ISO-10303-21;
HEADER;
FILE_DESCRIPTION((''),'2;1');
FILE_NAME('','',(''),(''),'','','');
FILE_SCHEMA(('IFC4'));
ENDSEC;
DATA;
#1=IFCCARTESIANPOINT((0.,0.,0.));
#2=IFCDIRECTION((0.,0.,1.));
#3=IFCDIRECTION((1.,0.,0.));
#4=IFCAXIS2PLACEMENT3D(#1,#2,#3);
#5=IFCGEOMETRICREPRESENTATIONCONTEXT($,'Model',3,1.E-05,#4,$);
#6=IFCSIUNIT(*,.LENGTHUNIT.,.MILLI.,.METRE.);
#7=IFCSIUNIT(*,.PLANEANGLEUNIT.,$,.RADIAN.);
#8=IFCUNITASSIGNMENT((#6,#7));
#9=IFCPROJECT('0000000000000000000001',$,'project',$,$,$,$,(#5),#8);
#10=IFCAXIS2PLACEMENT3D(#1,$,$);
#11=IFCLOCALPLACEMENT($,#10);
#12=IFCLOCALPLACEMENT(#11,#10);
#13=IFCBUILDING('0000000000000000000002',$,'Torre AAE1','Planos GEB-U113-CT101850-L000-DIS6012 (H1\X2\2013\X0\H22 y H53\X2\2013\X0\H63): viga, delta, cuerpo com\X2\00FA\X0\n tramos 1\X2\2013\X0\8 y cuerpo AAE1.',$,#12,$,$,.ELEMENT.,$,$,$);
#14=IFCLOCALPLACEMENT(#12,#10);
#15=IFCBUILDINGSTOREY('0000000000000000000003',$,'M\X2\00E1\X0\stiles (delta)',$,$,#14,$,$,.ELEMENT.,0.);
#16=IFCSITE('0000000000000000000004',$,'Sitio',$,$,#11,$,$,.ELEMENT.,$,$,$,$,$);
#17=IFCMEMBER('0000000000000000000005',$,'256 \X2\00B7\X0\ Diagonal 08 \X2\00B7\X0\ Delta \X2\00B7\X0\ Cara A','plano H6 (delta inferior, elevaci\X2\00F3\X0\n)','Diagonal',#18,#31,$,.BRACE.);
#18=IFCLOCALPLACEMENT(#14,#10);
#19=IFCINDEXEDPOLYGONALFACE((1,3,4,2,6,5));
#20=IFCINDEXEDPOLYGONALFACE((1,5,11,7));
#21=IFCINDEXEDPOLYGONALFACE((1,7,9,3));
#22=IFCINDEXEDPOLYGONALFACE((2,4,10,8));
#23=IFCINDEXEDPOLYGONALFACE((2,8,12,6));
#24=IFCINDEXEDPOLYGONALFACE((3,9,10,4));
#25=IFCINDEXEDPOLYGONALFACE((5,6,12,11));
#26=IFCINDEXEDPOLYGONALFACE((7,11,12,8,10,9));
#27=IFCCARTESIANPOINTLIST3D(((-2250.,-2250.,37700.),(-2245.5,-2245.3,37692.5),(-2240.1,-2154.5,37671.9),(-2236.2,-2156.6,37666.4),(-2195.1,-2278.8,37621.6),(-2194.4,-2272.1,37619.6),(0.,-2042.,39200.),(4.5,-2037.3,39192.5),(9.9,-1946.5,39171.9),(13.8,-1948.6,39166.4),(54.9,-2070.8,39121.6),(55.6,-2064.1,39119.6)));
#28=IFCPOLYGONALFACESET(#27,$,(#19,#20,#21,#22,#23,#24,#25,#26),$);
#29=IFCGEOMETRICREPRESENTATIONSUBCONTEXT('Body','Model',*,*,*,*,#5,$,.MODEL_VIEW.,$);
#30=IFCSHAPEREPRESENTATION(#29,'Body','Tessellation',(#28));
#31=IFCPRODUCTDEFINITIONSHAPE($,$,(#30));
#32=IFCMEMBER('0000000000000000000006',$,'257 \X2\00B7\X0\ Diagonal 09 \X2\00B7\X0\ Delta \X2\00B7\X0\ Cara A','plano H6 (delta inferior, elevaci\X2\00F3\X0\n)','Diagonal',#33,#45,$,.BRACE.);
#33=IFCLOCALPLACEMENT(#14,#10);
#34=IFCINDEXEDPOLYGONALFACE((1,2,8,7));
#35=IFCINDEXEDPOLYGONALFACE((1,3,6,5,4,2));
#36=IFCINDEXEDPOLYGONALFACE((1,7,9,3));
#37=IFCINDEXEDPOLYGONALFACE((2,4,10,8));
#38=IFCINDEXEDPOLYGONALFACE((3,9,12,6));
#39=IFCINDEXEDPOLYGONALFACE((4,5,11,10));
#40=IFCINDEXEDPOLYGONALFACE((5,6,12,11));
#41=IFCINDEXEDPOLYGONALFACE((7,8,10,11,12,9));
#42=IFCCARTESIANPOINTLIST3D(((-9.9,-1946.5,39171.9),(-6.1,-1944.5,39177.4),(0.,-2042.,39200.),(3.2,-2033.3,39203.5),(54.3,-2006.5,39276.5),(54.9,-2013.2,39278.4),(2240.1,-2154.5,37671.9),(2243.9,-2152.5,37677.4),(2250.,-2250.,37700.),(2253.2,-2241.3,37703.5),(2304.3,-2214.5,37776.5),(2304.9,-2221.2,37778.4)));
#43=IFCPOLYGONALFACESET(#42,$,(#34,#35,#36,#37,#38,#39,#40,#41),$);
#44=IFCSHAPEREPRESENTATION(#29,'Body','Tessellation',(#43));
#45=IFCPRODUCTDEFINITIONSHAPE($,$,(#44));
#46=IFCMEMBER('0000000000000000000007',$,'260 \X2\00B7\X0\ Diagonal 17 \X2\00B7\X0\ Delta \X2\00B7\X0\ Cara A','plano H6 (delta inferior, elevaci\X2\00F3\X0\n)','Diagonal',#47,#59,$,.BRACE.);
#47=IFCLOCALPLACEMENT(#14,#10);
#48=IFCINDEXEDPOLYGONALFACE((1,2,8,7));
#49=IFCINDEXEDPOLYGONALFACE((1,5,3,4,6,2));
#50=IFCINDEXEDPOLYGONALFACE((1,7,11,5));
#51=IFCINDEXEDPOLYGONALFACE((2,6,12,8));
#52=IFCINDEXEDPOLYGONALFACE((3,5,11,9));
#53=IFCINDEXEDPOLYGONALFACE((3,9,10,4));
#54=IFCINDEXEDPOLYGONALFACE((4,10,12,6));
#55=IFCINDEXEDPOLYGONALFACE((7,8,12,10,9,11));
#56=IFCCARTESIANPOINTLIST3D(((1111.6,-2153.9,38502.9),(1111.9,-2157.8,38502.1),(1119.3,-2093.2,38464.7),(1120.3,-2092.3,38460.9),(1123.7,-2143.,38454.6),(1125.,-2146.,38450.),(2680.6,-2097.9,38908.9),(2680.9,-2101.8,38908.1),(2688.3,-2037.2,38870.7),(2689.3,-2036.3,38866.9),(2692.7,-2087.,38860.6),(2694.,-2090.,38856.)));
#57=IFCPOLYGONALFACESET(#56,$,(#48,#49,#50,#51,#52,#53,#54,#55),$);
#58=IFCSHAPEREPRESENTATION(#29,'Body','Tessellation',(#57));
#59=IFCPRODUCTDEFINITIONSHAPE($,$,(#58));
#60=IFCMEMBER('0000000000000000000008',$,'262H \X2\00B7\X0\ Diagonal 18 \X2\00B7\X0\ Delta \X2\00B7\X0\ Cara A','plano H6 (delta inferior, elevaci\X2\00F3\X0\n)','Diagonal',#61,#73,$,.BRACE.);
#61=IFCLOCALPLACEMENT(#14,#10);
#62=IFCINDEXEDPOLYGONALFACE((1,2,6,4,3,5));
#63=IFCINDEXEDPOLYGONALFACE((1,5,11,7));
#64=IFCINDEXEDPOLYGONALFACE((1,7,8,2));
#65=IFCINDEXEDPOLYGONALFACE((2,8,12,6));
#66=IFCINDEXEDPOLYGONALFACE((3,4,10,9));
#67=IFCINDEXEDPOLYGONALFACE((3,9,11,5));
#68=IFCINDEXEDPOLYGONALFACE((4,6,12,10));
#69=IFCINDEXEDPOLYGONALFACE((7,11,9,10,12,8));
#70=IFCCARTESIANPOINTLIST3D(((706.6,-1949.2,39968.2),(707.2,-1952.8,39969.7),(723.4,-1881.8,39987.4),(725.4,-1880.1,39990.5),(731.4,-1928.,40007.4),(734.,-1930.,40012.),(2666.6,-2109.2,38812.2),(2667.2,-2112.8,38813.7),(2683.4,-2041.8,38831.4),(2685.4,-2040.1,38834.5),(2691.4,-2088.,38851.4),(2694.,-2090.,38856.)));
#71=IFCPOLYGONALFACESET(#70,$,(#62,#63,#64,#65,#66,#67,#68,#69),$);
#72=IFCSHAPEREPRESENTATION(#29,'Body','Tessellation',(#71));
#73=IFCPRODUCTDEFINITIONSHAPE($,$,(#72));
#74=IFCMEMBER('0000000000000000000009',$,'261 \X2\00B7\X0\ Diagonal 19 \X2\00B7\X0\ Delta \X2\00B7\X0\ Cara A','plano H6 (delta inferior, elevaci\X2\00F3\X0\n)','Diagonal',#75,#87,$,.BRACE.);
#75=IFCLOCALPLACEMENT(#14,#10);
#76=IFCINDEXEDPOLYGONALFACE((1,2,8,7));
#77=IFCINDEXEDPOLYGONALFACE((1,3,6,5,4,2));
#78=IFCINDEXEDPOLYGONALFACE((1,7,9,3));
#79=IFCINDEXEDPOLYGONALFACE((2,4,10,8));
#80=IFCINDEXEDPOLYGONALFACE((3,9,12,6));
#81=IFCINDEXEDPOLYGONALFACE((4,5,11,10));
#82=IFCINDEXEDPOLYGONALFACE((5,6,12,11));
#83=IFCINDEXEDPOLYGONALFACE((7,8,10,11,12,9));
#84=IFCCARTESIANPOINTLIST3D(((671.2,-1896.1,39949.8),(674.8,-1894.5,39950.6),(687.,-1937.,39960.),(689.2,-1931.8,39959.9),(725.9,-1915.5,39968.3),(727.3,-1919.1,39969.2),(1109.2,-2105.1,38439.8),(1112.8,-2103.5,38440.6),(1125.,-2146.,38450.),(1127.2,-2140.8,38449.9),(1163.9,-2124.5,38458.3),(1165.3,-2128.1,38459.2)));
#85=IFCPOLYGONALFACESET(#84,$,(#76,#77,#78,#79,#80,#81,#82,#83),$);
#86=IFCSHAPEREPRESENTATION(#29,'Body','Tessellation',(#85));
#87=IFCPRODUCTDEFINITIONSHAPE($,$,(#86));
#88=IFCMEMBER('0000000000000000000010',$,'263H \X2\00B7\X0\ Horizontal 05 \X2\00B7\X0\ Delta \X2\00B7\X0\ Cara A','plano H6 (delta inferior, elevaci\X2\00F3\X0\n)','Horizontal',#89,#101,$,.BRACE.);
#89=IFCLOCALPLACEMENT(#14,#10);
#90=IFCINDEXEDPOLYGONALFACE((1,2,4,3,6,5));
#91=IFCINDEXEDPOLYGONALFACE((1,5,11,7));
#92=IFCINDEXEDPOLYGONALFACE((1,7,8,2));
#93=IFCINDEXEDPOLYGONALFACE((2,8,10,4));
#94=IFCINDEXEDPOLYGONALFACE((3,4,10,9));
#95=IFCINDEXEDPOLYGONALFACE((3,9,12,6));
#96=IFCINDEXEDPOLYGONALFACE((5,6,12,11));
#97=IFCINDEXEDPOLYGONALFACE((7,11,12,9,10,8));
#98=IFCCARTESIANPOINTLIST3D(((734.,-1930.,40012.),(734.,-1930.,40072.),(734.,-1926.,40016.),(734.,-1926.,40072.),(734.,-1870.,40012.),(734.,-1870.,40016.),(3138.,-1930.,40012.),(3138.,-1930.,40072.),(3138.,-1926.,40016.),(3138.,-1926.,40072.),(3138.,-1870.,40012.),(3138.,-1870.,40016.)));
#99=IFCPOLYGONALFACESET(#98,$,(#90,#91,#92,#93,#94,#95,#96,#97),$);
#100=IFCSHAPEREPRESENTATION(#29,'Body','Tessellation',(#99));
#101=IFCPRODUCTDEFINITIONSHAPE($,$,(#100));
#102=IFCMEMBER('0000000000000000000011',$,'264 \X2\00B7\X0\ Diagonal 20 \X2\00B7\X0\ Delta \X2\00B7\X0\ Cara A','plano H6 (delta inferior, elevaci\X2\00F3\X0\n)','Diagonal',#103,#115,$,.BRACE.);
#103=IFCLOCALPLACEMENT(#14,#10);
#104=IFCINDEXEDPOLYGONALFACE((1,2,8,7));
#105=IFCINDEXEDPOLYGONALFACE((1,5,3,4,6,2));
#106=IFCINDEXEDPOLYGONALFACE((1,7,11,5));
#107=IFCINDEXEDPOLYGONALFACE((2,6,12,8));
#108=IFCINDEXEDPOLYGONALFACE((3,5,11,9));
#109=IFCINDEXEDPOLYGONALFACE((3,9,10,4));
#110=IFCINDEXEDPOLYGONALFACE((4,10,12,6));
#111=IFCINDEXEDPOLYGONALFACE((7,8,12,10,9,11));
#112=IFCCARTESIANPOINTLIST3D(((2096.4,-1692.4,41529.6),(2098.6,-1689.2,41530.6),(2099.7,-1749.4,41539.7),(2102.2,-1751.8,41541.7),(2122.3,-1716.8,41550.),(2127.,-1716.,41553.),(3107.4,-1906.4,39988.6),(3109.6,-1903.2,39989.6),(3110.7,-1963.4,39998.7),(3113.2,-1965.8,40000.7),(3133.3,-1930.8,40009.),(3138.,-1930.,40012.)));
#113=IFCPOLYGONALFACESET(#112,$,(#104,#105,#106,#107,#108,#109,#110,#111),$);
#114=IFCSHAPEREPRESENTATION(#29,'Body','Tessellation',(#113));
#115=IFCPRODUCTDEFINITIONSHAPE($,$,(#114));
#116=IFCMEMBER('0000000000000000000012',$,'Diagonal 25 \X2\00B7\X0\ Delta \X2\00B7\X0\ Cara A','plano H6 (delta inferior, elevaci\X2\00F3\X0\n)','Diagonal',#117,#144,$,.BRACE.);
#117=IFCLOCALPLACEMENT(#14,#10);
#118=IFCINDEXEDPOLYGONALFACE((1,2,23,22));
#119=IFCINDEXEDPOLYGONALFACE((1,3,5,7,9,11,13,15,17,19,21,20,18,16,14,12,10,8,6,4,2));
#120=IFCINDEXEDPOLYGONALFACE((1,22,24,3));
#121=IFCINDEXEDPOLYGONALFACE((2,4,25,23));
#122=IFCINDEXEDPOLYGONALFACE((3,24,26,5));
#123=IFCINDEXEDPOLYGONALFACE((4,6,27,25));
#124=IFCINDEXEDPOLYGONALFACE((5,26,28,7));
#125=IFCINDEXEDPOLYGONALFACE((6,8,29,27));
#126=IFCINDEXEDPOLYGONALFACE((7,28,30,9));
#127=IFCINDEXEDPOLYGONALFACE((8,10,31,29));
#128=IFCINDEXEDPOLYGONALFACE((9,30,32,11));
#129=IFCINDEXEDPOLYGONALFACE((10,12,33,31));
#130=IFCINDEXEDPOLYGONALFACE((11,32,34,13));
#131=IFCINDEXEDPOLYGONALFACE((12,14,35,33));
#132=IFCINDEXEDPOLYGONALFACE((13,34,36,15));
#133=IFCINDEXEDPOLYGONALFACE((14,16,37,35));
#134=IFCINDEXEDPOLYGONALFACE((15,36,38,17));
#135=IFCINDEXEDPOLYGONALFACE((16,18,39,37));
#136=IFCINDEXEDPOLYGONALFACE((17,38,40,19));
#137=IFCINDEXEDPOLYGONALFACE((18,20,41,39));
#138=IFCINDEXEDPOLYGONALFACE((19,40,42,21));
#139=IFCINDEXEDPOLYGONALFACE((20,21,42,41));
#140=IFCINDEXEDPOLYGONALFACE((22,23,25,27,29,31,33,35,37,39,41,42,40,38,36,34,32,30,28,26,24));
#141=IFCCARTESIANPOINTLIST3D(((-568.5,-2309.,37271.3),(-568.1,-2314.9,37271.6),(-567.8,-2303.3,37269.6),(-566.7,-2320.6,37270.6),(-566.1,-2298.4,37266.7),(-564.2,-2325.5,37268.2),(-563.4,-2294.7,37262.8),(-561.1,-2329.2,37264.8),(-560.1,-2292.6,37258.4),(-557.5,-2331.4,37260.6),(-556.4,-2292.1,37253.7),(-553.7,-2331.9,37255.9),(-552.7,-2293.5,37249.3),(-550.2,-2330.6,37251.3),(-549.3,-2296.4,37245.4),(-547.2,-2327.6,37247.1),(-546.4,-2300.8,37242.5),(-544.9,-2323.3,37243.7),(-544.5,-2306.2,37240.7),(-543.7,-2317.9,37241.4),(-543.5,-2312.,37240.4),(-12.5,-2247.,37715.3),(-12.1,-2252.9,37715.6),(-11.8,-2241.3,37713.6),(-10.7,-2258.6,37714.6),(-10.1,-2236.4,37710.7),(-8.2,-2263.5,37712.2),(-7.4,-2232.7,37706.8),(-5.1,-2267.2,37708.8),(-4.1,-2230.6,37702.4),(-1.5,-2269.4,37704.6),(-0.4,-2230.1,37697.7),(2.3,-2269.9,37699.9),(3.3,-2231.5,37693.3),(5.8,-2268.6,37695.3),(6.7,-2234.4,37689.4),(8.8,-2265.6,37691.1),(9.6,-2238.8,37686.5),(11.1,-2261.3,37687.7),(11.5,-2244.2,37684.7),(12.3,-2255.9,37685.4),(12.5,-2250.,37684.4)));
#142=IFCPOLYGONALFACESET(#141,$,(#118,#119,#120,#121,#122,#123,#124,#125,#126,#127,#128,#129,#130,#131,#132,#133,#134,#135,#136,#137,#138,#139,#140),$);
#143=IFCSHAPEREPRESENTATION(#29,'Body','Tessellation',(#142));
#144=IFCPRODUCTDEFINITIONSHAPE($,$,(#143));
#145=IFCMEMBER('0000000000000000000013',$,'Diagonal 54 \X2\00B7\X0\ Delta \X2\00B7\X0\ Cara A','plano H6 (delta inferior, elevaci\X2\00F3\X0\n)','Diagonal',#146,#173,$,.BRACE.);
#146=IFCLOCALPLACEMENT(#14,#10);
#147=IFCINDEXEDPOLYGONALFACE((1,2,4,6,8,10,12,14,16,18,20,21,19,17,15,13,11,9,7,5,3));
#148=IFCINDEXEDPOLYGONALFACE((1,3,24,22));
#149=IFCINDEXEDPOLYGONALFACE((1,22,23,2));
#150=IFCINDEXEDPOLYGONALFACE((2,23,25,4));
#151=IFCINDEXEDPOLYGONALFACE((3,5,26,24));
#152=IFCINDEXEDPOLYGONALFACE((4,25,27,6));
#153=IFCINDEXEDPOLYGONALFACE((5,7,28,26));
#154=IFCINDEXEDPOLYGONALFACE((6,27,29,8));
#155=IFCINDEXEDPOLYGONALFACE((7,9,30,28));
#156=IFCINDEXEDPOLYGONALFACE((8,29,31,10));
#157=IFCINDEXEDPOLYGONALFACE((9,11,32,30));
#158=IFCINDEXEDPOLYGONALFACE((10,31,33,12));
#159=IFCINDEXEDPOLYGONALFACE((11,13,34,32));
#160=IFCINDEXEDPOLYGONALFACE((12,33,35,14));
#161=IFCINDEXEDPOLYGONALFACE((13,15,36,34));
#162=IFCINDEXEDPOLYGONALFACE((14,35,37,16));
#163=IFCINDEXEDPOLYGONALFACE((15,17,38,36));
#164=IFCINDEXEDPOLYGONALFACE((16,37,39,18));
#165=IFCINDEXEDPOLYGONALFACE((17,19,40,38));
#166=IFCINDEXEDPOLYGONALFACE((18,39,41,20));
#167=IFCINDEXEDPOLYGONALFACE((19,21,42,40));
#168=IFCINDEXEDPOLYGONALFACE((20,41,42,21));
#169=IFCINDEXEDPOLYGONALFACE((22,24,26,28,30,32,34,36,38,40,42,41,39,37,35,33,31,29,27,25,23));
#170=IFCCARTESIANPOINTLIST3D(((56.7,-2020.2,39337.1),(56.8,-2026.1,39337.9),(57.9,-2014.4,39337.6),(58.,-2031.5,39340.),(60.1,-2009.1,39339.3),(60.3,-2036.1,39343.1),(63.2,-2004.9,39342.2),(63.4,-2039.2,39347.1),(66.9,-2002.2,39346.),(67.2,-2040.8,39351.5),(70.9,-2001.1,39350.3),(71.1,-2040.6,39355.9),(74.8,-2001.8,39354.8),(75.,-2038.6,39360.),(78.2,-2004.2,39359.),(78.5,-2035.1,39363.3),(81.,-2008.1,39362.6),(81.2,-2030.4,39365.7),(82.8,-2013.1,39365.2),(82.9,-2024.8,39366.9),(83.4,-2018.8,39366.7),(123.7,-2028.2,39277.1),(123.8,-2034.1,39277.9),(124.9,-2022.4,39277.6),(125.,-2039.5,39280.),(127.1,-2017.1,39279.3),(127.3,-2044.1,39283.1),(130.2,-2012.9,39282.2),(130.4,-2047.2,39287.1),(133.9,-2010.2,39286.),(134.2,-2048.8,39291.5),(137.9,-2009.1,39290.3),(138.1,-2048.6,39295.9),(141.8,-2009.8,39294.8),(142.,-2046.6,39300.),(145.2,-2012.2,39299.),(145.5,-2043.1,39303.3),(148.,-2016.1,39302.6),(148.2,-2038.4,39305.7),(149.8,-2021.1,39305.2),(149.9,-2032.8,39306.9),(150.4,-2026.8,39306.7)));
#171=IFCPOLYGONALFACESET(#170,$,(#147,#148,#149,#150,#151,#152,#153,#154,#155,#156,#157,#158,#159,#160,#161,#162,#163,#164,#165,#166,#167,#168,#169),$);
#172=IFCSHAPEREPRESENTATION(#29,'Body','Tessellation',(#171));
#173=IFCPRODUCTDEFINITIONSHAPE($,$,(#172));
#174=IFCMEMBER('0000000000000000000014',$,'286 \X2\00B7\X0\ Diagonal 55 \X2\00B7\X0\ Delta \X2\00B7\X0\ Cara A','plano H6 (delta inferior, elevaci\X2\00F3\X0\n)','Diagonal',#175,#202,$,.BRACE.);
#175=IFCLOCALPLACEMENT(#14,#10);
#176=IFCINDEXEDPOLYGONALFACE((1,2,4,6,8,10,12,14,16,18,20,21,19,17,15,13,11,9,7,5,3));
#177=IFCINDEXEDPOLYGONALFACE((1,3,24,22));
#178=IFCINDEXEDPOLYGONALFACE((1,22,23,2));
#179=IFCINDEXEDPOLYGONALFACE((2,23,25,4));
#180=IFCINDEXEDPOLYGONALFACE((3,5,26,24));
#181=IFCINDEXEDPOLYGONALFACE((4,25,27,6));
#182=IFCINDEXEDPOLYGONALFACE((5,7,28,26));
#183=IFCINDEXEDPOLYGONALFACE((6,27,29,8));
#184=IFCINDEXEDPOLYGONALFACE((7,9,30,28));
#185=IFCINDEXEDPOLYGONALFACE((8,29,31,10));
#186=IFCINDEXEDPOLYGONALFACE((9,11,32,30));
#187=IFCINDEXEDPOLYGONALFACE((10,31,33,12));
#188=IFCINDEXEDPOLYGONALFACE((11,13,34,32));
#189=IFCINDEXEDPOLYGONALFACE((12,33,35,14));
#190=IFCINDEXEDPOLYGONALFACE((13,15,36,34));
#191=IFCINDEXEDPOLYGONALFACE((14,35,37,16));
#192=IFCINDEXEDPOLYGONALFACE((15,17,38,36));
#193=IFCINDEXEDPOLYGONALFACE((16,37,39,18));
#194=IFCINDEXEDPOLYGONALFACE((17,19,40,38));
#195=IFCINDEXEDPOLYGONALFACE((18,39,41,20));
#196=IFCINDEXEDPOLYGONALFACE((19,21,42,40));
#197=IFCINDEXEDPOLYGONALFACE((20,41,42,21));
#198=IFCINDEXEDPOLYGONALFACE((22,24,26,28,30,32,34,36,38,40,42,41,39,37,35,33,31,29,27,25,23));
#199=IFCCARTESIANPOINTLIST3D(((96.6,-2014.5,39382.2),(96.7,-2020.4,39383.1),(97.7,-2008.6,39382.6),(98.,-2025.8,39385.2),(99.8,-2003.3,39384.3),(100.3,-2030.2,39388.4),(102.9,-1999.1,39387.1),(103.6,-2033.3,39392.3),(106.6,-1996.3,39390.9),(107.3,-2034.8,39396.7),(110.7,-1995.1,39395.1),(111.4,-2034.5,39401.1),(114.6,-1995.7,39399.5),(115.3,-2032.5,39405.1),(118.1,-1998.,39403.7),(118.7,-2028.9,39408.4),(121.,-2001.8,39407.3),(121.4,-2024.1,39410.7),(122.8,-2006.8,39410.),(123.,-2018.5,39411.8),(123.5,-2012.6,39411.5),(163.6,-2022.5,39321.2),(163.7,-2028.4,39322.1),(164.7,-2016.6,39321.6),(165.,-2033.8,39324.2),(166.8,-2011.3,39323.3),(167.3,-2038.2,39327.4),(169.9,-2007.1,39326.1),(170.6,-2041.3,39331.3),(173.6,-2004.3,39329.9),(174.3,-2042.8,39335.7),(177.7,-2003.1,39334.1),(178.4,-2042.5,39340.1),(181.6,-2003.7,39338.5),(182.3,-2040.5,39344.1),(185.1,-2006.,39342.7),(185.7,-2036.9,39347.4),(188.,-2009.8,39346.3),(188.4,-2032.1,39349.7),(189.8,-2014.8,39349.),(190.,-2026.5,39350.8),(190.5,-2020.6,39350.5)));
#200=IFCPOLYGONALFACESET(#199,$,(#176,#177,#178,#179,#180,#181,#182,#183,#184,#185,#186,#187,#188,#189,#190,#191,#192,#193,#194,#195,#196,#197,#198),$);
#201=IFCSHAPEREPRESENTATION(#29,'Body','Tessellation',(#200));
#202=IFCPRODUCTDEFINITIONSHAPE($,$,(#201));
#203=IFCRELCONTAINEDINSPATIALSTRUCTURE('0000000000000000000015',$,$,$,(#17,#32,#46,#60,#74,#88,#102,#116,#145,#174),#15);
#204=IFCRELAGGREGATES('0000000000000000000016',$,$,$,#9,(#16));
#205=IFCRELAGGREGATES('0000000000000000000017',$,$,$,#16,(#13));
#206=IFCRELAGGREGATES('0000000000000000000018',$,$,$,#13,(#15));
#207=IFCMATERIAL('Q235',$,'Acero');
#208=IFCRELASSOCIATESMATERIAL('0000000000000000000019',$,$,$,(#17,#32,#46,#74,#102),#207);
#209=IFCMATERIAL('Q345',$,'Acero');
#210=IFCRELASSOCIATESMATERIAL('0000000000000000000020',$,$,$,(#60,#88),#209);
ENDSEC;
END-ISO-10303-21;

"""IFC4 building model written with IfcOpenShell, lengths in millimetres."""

from ifc_helpers import new_model, si_unit, frame, frame_2d, origin, origin_with_axes, place, context, subcontext, project, spatial, circle, l_section, extrude, material, element, save


model = new_model("IFC4")

# Units and contexts
model_context = context("Model", 3, precision=1e-05, world=origin_with_axes())
body_context = subcontext(model_context, "Body", "Model", "MODEL_VIEW")
ifc_project = project(units=[si_unit("LENGTHUNIT", "METRE", prefix="MILLI"), si_unit("PLANEANGLEUNIT", "RADIAN")], contexts=[model_context])

# Site, building, storey
site_placement = place(None, origin())
site = spatial("IfcSite", under=ifc_project, at=site_placement, Name="Sitio", CompositionType="ELEMENT")
building_placement = place(site_placement, origin())
building = spatial("IfcBuilding", under=site, at=building_placement, Name="Torre AAE1", Description="Planos GEB-U113-CT101850-L000-DIS6012 (H1–H22 y H53–H63): viga, delta, cuerpo común tramos 1–8 y cuerpo AAE1.", CompositionType="ELEMENT")
storey_placement = place(building_placement, origin())
storey = spatial("IfcBuildingStorey", under=building, at=storey_placement, Name="Mástiles (delta)", CompositionType="ELEMENT", Elevation=0.0)

# Members
ifc_material_1 = material(Name="Q235", Category="Acero")
for number, where, z_axis, x_axis, name in (
    (1, (0.0, -2042.0, 39200.0), (-0.8296, -0.076692, -0.553067), (0.099166, 0.954538, -0.281112), "256 · Diagonal 08 · Delta · Cara A"),
    (2, (0.0, -2042.0, 39200.0), (0.8296, -0.076692, -0.553067), (-0.099166, 0.954538, -0.281112), "257 · Diagonal 09 · Delta · Cara A"),
):
    element("IfcMember", number, at=place(storey_placement, frame(where, z_axis=z_axis, x_axis=x_axis)), inside=storey, material=ifc_material_1, Name=name, Description="plano H6 (delta inferior, elevación)", ObjectType="Diagonal", PredefinedType="BRACE", context=body_context, shape_type="SweptSolid", body=[
        extrude(l_section(Depth=100.0, Width=100.0, Thickness=7.0, at=frame_2d((50.0, 50.0))), None, (0.0, 0.0, 1.0), 2712.2),
    ])
member_1_placement = place(storey_placement, frame((1125.0, -2146.0, 38450.0), z_axis=(0.967536, 0.034533, 0.250363), x_axis=(-0.086334, 0.976191, 0.198993)))
element("IfcMember", 3, at=member_1_placement, inside=storey, material=ifc_material_1, Name="260 · Diagonal 17 · Delta · Cara A", Description="plano H6 (delta inferior, elevación)", ObjectType="Diagonal", PredefinedType="BRACE", context=body_context, shape_type="SweptSolid", body=[
    extrude(l_section(Depth=55.0, Width=55.0, Thickness=4.0, at=frame_2d((27.5, 27.5))), None, (0.0, 0.0, 1.0), 1621.6),
])
ifc_material_2 = material(Name="Q345", Category="Acero")
member_2_placement = place(storey_placement, frame((2694.0, -2090.0, 38856.0), z_axis=(-0.859225, 0.070141, 0.506767), x_axis=(-0.156582, 0.906966, -0.391017)))
element("IfcMember", 4, at=member_2_placement, inside=storey, material=ifc_material_2, Name="262H · Diagonal 18 · Delta · Cara A", Description="plano H6 (delta inferior, elevación)", ObjectType="Diagonal", PredefinedType="BRACE", context=body_context, shape_type="SweptSolid", body=[
    extrude(l_section(Depth=55.0, Width=55.0, Thickness=4.0, at=frame_2d((27.5, 27.5))), None, (0.0, 0.0, 1.0), 2281.1),
])
member_3_placement = place(storey_placement, frame((687.0, -1937.0, 39960.0), z_axis=(0.276154, -0.131772, -0.952037), x_axis=(-0.351062, 0.908283, -0.227547)))
element("IfcMember", 5, at=member_3_placement, inside=storey, material=ifc_material_1, Name="261 · Diagonal 19 · Delta · Cara A", Description="plano H6 (delta inferior, elevación)", ObjectType="Diagonal", PredefinedType="BRACE", context=body_context, shape_type="SweptSolid", body=[
    extrude(l_section(Depth=45.0, Width=45.0, Thickness=4.0, at=frame_2d((22.5, 22.5))), None, (0.0, 0.0, 1.0), 1586.1),
])
member_4_placement = place(storey_placement, frame((734.0, -1930.0, 40012.0), z_axis=(1.0, 0.0, 0.0), x_axis=(0.0, 1.0, 0.0)))
element("IfcMember", 6, at=member_4_placement, inside=storey, material=ifc_material_2, Name="263H · Horizontal 05 · Delta · Cara A", Description="plano H6 (delta inferior, elevación)", ObjectType="Horizontal", PredefinedType="BRACE", context=body_context, shape_type="SweptSolid", body=[
    extrude(l_section(Depth=60.0, Width=60.0, Thickness=4.0, at=frame_2d((30.0, 30.0))), None, (0.0, 0.0, 1.0), 2404.0),
])
member_5_placement = place(storey_placement, frame((3138.0, -1930.0, 40012.0), z_axis=(-0.544889, 0.115338, 0.830538), x_axis=(-0.631982, 0.594484, -0.49718)))
element("IfcMember", 7, at=member_5_placement, inside=storey, material=ifc_material_1, Name="264 · Diagonal 20 · Delta · Cara A", Description="plano H6 (delta inferior, elevación)", ObjectType="Diagonal", PredefinedType="BRACE", context=body_context, shape_type="SweptSolid", body=[
    extrude(l_section(Depth=45.0, Width=45.0, Thickness=4.0, at=frame_2d((22.5, 22.5))), None, (0.0, 0.0, 1.0), 1855.4),
])
member_6_placement = place(storey_placement, frame((0.0, -2250.0, 37700.0), z_axis=(-0.778467, -0.086807, -0.621654), x_axis=(-0.019739, 0.993286, -0.113984)))
element("IfcMember", 8, at=member_6_placement, inside=storey, Name="Diagonal 25 · Delta · Cara A", Description="plano H6 (delta inferior, elevación)", ObjectType="Diagonal", PredefinedType="BRACE", context=body_context, shape_type="SweptSolid", body=[
    extrude(circle(Radius=20.0), None, (0.0, 0.0, 1.0), 714.2),
])
member_7_placement = place(storey_placement, frame((137.0, -2029.0, 39292.0), z_axis=(-0.742021, 0.088599, 0.664496), x_axis=(0.043062, 0.99548, -0.084644)))
element("IfcMember", 9, at=member_7_placement, inside=storey, Name="Diagonal 54 · Delta · Cara A", Description="plano H6 (delta inferior, elevación)", ObjectType="Diagonal", PredefinedType="BRACE", context=body_context, shape_type="SweptSolid", body=[
    extrude(circle(Radius=20.0), None, (0.0, 0.0, 1.0), 90.3),
])
member_8_placement = place(storey_placement, frame((177.0, -2023.0, 39336.0), z_axis=(-0.736575, 0.087949, 0.670613), x_axis=(0.032506, 0.994967, -0.094784)))
element("IfcMember", 10, at=member_8_placement, inside=storey, Name="286 · Diagonal 55 · Delta · Cara A", Description="plano H6 (delta inferior, elevación)", ObjectType="Diagonal", PredefinedType="BRACE", context=body_context, shape_type="SweptSolid", body=[
    extrude(circle(Radius=20.0), None, (0.0, 0.0, 1.0), 91.0),
])

save(model, "model.ifc")
